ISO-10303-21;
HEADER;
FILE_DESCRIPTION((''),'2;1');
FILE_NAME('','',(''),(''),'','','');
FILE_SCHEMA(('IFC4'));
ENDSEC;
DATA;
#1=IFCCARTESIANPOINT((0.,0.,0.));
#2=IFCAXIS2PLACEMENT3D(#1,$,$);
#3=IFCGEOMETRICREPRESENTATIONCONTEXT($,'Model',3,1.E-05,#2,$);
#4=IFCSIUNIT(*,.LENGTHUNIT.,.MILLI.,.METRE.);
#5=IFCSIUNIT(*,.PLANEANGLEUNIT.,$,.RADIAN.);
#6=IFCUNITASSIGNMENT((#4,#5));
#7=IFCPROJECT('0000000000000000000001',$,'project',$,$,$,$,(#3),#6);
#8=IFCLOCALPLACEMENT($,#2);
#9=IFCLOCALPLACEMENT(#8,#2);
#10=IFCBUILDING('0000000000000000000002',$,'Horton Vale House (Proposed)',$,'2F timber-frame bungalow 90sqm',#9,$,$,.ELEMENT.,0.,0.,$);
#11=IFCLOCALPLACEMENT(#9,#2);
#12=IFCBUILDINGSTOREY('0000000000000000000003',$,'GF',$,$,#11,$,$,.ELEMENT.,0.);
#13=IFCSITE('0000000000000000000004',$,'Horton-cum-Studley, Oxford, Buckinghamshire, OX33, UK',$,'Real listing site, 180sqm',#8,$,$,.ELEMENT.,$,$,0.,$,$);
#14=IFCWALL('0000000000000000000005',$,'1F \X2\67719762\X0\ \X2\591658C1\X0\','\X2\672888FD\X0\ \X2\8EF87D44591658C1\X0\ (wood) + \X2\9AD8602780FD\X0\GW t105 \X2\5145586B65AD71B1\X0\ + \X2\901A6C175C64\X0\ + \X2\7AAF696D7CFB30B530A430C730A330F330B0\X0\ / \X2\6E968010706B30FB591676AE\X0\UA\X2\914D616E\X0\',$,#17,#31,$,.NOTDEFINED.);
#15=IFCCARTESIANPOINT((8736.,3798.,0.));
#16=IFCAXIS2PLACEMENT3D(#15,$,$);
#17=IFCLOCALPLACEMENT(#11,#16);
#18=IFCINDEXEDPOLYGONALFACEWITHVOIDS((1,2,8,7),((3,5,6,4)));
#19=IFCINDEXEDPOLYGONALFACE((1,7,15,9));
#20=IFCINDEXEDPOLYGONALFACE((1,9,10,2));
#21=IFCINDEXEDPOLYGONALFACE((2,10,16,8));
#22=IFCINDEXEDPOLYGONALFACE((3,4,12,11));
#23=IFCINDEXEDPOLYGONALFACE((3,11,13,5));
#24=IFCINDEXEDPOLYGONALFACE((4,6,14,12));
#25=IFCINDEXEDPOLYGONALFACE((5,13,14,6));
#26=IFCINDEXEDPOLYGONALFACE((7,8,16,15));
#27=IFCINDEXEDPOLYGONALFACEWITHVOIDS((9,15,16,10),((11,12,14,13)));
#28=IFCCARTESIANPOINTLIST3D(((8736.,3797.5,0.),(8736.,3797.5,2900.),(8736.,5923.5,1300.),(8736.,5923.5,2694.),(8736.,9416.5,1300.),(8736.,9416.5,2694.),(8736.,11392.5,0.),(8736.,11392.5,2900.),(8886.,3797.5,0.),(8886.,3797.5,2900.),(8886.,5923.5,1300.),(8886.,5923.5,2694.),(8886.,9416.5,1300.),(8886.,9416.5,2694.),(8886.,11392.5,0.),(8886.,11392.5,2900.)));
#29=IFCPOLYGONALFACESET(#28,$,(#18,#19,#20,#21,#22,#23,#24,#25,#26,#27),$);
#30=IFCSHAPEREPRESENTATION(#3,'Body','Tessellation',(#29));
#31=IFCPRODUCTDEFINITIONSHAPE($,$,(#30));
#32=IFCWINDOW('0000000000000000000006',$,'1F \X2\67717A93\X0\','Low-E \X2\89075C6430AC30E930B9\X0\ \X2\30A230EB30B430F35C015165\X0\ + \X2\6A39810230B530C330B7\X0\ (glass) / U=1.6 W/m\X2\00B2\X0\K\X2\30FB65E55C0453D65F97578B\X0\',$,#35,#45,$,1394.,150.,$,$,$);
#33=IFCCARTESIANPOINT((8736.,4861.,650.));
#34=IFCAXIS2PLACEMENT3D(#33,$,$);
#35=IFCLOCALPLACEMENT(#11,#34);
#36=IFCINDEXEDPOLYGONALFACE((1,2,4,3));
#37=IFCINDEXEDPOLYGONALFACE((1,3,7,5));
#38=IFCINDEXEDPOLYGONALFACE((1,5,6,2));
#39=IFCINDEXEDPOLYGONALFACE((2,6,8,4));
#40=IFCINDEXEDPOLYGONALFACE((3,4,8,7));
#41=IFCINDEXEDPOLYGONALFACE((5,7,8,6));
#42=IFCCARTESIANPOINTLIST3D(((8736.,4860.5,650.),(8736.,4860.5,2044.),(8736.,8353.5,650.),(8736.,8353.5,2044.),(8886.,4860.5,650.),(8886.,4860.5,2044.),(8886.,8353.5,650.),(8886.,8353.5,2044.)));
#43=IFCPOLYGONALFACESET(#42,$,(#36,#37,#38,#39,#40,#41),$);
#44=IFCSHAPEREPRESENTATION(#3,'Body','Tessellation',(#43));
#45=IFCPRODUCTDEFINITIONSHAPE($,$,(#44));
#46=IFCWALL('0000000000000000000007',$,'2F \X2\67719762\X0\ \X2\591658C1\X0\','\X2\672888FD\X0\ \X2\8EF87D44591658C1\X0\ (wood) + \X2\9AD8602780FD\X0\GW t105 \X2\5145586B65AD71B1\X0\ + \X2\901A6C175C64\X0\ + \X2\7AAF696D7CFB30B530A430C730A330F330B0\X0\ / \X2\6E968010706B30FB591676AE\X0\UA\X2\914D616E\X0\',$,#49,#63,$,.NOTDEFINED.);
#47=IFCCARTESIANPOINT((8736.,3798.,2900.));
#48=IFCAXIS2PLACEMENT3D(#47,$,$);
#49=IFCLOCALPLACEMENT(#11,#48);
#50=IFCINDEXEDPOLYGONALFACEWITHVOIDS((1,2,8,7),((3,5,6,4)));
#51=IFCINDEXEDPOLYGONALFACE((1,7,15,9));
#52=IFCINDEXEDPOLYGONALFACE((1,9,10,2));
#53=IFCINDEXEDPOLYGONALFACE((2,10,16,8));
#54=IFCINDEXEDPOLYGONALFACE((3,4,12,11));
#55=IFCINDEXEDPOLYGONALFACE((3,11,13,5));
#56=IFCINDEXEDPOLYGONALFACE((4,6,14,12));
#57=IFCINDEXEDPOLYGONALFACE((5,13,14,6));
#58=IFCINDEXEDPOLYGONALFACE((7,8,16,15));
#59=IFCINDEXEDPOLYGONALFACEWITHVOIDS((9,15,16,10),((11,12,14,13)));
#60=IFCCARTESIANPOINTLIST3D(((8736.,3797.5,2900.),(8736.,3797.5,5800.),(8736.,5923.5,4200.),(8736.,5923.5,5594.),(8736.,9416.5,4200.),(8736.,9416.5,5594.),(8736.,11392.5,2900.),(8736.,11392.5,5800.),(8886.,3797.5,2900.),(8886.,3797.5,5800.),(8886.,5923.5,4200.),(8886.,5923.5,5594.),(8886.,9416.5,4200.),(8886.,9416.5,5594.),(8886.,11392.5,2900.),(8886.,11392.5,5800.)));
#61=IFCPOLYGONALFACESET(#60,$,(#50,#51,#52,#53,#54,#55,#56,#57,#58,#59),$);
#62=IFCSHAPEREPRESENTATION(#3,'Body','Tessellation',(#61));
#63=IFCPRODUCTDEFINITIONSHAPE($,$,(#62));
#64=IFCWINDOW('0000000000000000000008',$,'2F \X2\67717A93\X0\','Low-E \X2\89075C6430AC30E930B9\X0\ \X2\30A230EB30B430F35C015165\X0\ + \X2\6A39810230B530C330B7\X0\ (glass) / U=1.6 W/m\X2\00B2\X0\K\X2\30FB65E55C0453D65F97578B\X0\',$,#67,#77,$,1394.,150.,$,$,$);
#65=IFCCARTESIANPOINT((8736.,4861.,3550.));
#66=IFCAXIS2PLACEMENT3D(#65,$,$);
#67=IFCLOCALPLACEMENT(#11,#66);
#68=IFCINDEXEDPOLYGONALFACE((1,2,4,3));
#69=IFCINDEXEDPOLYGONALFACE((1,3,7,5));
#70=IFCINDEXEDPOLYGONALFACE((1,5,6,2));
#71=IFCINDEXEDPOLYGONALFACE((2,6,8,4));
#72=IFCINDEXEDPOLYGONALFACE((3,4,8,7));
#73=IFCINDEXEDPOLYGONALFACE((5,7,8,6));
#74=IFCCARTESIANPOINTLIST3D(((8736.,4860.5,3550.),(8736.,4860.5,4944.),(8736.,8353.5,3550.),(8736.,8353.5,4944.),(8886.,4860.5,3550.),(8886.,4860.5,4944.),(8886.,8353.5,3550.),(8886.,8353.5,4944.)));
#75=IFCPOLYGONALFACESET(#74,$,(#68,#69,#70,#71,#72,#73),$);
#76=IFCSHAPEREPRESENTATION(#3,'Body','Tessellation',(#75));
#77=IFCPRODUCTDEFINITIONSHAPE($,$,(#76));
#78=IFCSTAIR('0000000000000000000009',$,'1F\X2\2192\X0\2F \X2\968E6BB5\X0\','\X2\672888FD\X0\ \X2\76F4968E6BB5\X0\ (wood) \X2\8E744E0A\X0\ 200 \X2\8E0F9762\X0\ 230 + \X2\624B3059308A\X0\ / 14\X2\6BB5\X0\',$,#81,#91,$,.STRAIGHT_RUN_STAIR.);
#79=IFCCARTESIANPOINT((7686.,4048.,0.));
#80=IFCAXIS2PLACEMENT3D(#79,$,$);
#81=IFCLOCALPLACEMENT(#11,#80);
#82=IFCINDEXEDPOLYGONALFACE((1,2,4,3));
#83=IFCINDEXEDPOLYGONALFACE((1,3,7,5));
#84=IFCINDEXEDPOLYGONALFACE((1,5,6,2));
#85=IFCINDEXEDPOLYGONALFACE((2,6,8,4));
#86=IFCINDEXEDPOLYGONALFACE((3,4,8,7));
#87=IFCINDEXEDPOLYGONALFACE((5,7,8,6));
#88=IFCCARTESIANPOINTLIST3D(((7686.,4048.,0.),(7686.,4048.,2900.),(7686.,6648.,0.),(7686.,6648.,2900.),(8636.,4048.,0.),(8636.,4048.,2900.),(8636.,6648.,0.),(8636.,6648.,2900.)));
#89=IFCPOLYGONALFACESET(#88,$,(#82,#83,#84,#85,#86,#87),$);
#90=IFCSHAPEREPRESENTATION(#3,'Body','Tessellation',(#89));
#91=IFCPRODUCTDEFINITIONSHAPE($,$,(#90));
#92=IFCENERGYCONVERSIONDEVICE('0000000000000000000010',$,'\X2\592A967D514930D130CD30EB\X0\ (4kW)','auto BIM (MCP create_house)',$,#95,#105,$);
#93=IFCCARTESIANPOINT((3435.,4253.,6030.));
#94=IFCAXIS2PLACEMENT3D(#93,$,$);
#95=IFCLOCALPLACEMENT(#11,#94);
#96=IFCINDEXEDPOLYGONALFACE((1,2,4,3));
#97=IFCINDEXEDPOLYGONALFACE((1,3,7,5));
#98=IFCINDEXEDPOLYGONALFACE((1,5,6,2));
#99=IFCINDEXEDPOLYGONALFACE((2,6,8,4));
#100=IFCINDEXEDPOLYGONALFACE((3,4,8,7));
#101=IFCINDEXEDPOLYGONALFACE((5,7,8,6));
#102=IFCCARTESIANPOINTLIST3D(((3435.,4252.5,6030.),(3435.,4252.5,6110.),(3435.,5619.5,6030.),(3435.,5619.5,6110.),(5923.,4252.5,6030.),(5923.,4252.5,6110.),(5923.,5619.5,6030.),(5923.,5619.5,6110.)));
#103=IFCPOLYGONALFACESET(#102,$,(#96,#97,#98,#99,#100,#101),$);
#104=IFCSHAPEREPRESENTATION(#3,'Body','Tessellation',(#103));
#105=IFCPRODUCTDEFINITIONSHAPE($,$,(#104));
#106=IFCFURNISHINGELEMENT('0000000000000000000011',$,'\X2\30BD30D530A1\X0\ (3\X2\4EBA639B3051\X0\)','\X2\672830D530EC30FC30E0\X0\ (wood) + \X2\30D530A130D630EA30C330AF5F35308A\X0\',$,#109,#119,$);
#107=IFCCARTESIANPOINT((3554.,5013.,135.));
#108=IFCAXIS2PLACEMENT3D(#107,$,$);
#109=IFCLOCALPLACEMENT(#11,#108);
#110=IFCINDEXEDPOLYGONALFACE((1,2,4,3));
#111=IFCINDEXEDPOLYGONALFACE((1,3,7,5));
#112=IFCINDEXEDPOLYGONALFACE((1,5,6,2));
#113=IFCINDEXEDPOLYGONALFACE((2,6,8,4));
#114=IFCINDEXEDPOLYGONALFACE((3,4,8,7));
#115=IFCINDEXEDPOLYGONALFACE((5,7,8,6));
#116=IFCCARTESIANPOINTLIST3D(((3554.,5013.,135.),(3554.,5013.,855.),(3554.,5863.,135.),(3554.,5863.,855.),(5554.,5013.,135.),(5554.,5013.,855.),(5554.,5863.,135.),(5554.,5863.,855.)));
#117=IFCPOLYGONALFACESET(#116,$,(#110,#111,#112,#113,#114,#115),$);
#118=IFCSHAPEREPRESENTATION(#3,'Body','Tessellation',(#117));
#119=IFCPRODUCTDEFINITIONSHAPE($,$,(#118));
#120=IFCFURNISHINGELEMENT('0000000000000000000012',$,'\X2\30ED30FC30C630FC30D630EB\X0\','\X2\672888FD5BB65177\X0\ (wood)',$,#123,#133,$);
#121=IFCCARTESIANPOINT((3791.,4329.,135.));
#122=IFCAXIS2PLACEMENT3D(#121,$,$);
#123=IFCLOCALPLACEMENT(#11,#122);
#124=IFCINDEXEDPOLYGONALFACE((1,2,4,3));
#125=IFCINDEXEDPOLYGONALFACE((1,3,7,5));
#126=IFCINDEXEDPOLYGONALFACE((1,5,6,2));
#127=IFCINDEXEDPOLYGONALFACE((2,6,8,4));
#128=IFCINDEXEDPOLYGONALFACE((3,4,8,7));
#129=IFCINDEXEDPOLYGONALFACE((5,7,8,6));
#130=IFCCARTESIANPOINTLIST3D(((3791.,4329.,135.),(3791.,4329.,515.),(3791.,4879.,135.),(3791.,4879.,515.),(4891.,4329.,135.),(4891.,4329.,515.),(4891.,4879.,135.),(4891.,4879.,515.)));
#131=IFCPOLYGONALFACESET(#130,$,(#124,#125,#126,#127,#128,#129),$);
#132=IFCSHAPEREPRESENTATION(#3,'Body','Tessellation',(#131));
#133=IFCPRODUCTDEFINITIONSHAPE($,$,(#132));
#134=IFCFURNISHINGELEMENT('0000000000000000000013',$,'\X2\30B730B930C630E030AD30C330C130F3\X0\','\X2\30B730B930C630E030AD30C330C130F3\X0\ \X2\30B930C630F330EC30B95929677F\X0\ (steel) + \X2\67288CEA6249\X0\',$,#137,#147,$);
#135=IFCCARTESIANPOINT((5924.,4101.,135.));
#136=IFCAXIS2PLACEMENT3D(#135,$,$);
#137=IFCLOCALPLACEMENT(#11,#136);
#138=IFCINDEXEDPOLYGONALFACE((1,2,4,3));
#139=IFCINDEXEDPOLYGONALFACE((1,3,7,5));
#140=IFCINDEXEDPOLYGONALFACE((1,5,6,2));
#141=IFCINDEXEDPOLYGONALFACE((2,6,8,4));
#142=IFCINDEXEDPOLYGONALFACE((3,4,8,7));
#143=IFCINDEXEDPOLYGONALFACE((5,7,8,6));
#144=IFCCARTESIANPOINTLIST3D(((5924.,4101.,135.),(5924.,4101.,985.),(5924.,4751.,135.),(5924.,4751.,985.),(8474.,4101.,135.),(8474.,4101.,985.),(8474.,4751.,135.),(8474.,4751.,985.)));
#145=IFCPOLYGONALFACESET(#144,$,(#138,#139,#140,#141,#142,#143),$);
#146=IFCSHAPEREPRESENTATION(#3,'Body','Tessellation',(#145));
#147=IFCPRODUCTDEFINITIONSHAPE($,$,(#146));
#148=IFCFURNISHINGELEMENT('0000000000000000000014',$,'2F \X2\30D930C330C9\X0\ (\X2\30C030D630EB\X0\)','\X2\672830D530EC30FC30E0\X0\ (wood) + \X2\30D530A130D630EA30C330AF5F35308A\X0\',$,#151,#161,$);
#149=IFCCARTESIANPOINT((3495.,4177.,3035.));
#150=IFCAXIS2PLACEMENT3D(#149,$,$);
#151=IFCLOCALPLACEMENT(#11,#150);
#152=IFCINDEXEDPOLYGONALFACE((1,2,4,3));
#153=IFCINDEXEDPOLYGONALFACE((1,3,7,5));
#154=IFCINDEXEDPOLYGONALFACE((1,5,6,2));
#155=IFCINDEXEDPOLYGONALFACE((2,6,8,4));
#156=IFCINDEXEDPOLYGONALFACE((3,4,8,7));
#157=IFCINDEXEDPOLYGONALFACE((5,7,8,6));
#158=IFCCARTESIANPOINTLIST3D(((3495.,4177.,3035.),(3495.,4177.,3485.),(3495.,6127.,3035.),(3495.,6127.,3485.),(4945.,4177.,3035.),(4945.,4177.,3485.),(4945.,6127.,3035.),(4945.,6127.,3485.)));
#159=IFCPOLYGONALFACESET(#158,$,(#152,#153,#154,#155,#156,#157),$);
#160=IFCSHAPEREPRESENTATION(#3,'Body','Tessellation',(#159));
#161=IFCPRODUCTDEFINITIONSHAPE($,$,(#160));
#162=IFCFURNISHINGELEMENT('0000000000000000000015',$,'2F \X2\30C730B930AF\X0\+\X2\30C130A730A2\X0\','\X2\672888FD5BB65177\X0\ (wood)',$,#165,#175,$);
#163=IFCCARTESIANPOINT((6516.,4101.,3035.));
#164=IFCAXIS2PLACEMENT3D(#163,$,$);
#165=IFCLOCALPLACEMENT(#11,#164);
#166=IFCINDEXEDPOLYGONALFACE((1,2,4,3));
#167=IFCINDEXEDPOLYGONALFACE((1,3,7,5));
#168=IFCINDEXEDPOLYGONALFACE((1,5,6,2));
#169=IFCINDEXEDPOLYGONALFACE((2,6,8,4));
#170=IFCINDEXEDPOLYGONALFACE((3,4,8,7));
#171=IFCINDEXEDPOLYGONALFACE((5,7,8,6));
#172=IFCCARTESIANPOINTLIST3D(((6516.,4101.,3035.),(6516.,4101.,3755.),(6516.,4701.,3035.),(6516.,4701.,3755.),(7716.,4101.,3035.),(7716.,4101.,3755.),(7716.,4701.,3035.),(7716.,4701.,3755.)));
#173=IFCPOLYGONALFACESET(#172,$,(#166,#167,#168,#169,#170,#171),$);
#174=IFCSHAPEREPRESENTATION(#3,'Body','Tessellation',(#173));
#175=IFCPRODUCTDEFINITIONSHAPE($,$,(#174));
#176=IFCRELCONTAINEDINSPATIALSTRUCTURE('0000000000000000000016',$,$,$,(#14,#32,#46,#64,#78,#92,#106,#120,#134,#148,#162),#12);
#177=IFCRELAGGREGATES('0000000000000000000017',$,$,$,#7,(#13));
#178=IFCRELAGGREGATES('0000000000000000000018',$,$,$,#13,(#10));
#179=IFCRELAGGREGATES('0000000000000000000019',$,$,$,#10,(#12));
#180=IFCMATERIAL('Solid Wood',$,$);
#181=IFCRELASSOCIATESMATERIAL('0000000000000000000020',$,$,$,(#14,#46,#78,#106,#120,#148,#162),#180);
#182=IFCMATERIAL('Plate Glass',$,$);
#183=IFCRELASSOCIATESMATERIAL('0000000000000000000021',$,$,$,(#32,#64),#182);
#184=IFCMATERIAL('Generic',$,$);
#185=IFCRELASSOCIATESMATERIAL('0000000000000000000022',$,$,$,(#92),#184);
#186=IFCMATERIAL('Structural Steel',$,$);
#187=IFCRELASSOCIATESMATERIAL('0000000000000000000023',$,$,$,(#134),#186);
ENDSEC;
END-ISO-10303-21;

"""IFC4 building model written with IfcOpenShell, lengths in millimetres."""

from ifc_helpers import new_model, si_unit, frame, frame_2d, origin, place, context, project, spatial, rectangle, extrude, material, element, fill, save


model = new_model("IFC4")

# Units and contexts
model_context = context("Model", 3, precision=1e-05, world=origin())
ifc_project = project(units=[si_unit("LENGTHUNIT", "METRE", prefix="MILLI"), si_unit("PLANEANGLEUNIT", "RADIAN")], contexts=[model_context])

# Site, building, storey
site_placement = place(None, origin())
site = spatial("IfcSite", under=ifc_project, at=site_placement, Name="Horton-cum-Studley, Oxford, Buckinghamshire, OX33, UK", ObjectType="Real listing site, 180sqm", CompositionType="ELEMENT", RefElevation=0.0)
building_placement = place(site_placement, origin())
building = spatial("IfcBuilding", under=site, at=building_placement, Name="Horton Vale House (Proposed)", ObjectType="2F timber-frame bungalow 90sqm", CompositionType="ELEMENT", ElevationOfRefHeight=0.0, ElevationOfTerrain=0.0)
storey_placement = place(building_placement, origin())
storey = spatial("IfcBuildingStorey", under=building, at=storey_placement, Name="GF", CompositionType="ELEMENT", Elevation=0.0)

# Wall, opening, window
ifc_material_1 = material(Name="Solid Wood")
wall_1_placement = place(storey_placement, frame((8736.0, 3798.0, 0.0)))
wall_1 = element("IfcWall", 1, at=wall_1_placement, inside=storey, material=ifc_material_1, Name="1F 東面 外壁", Description="木製 軸組外壁 (wood) + 高性能GW t105 充填断熱 + 通気層 + 窯業系サイディング / 準耐火・外皮UA配慮", PredefinedType="NOTDEFINED", context=model_context, shape_type="SweptSolid", body=[
    extrude(rectangle(XDim=150.0, YDim=7595.0, at=frame_2d((75.0, 3797.0))), frame((8736.0, 3798.0, 0.0)), (0.0, 0.0, 1.0), 2900.0),
])
opening_1_placement = place(storey_placement, frame((8736.0, 4861.0, 650.0)))
opening_1 = element("IfcOpeningElement", 2, at=opening_1_placement, cuts=wall_1, PredefinedType="NOTDEFINED", context=model_context, shape_type="SweptSolid", body=[
    extrude(rectangle(XDim=150.0, YDim=3493.0, at=frame_2d((75.0, 1746.0))), frame((8736.0, 4861.0, 650.0)), (0.0, 0.0, 1.0), 1394.0),
])
ifc_material_2 = material(Name="Plate Glass")
window_1_placement = place(storey_placement, frame((8736.0, 4861.0, 650.0)))
window_1 = element("IfcWindow", 3, at=window_1_placement, inside=storey, material=ifc_material_2, Name="1F 東窓", Description="Low-E 複層ガラス アルゴン封入 + 樹脂サッシ (glass) / U=1.6 W/m²K・日射取得型", OverallHeight=1394.0, OverallWidth=150.0, context=model_context, shape_type="SweptSolid", body=[
    extrude(rectangle(XDim=150.0, YDim=3493.0, at=frame_2d((75.0, 1746.0))), frame((8736.0, 4861.0, 650.0)), (0.0, 0.0, 1.0), 1394.0),
])
fill(opening_1, window_1)

# Wall, opening, window
wall_2_placement = place(storey_placement, frame((8736.0, 3798.0, 2900.0)))
wall_2 = element("IfcWall", 4, at=wall_2_placement, inside=storey, material=ifc_material_1, Name="2F 東面 外壁", Description="木製 軸組外壁 (wood) + 高性能GW t105 充填断熱 + 通気層 + 窯業系サイディング / 準耐火・外皮UA配慮", PredefinedType="NOTDEFINED", context=model_context, shape_type="SweptSolid", body=[
    extrude(rectangle(XDim=150.0, YDim=7595.0, at=frame_2d((75.0, 3797.0))), frame((8736.0, 3798.0, 2900.0)), (0.0, 0.0, 1.0), 2900.0),
])
opening_2_placement = place(storey_placement, frame((8736.0, 4861.0, 3550.0)))
opening_2 = element("IfcOpeningElement", 5, at=opening_2_placement, cuts=wall_2, PredefinedType="NOTDEFINED", context=model_context, shape_type="SweptSolid", body=[
    extrude(rectangle(XDim=150.0, YDim=3493.0, at=frame_2d((75.0, 1746.0))), frame((8736.0, 4861.0, 3550.0)), (0.0, 0.0, 1.0), 1394.0),
])
window_2_placement = place(storey_placement, frame((8736.0, 4861.0, 3550.0)))
window_2 = element("IfcWindow", 6, at=window_2_placement, inside=storey, material=ifc_material_2, Name="2F 東窓", Description="Low-E 複層ガラス アルゴン封入 + 樹脂サッシ (glass) / U=1.6 W/m²K・日射取得型", OverallHeight=1394.0, OverallWidth=150.0, context=model_context, shape_type="SweptSolid", body=[
    extrude(rectangle(XDim=150.0, YDim=3493.0, at=frame_2d((75.0, 1746.0))), frame((8736.0, 4861.0, 3550.0)), (0.0, 0.0, 1.0), 1394.0),
])
fill(opening_2, window_2)

# Stair
stair_placement = place(storey_placement, frame((7686.0, 4048.0, 0.0)))
element("IfcStair", 7, at=stair_placement, inside=storey, material=ifc_material_1, Name="1F→2F 階段", Description="木製 直階段 (wood) 蹴上 200 踏面 230 + 手すり / 14段", PredefinedType="STRAIGHT_RUN_STAIR", context=model_context, shape_type="SweptSolid", body=[
    extrude(rectangle(XDim=950.0, YDim=2600.0, at=frame_2d((475.0, 1300.0))), frame((7686.0, 4048.0, 0.0)), (0.0, 0.0, 1.0), 2900.0),
])

# Energy conversion device
ifc_material_3 = material(Name="Generic")
energy_conversion_device_placement = place(storey_placement, frame((3435.0, 4253.0, 6030.0)))
element("IfcEnergyConversionDevice", 8, at=energy_conversion_device_placement, inside=storey, material=ifc_material_3, Name="太陽光パネル (4kW)", Description="auto BIM (MCP create_house)", context=model_context, shape_type="SweptSolid", body=[
    extrude(rectangle(XDim=2488.0, YDim=1367.0, at=frame_2d((1244.0, 683.0))), frame((3435.0, 4253.0, 6030.0)), (0.0, 0.0, 1.0), 80.0),
])

# Furnishing elements
furnishing_1_placement = place(storey_placement, frame((3554.0, 5013.0, 135.0)))
element("IfcFurnishingElement", 9, at=furnishing_1_placement, inside=storey, material=ifc_material_1, Name="ソファ (3人掛け)", Description="木フレーム (wood) + ファブリック張り", context=model_context, shape_type="SweptSolid", body=[
    extrude(rectangle(XDim=2000.0, YDim=850.0, at=frame_2d((1000.0, 425.0))), frame((3554.0, 5013.0, 135.0)), (0.0, 0.0, 1.0), 720.0),
])
furnishing_2_placement = place(storey_placement, frame((3791.0, 4329.0, 135.0)))
element("IfcFurnishingElement", 10, at=furnishing_2_placement, inside=storey, material=ifc_material_1, Name="ローテーブル", Description="木製家具 (wood)", context=model_context, shape_type="SweptSolid", body=[
    extrude(rectangle(XDim=1100.0, YDim=550.0, at=frame_2d((550.0, 275.0))), frame((3791.0, 4329.0, 135.0)), (0.0, 0.0, 1.0), 380.0),
])
ifc_material_4 = material(Name="Structural Steel")
furnishing_3_placement = place(storey_placement, frame((5924.0, 4101.0, 135.0)))
element("IfcFurnishingElement", 11, at=furnishing_3_placement, inside=storey, material=ifc_material_4, Name="システムキッチン", Description="システムキッチン ステンレス天板 (steel) + 木質扉", context=model_context, shape_type="SweptSolid", body=[
    extrude(rectangle(XDim=2550.0, YDim=650.0, at=frame_2d((1275.0, 325.0))), frame((5924.0, 4101.0, 135.0)), (0.0, 0.0, 1.0), 850.0),
])
furnishing_4_placement = place(storey_placement, frame((3495.0, 4177.0, 3035.0)))
element("IfcFurnishingElement", 12, at=furnishing_4_placement, inside=storey, material=ifc_material_1, Name="2F ベッド (ダブル)", Description="木フレーム (wood) + ファブリック張り", context=model_context, shape_type="SweptSolid", body=[
    extrude(rectangle(XDim=1450.0, YDim=1950.0, at=frame_2d((725.0, 975.0))), frame((3495.0, 4177.0, 3035.0)), (0.0, 0.0, 1.0), 450.0),
])
furnishing_5_placement = place(storey_placement, frame((6516.0, 4101.0, 3035.0)))
element("IfcFurnishingElement", 13, at=furnishing_5_placement, inside=storey, material=ifc_material_1, Name="2F デスク+チェア", Description="木製家具 (wood)", context=model_context, shape_type="SweptSolid", body=[
    extrude(rectangle(XDim=1200.0, YDim=600.0, at=frame_2d((600.0, 300.0))), frame((6516.0, 4101.0, 3035.0)), (0.0, 0.0, 1.0), 720.0),
])

save(model, "model.ifc")
